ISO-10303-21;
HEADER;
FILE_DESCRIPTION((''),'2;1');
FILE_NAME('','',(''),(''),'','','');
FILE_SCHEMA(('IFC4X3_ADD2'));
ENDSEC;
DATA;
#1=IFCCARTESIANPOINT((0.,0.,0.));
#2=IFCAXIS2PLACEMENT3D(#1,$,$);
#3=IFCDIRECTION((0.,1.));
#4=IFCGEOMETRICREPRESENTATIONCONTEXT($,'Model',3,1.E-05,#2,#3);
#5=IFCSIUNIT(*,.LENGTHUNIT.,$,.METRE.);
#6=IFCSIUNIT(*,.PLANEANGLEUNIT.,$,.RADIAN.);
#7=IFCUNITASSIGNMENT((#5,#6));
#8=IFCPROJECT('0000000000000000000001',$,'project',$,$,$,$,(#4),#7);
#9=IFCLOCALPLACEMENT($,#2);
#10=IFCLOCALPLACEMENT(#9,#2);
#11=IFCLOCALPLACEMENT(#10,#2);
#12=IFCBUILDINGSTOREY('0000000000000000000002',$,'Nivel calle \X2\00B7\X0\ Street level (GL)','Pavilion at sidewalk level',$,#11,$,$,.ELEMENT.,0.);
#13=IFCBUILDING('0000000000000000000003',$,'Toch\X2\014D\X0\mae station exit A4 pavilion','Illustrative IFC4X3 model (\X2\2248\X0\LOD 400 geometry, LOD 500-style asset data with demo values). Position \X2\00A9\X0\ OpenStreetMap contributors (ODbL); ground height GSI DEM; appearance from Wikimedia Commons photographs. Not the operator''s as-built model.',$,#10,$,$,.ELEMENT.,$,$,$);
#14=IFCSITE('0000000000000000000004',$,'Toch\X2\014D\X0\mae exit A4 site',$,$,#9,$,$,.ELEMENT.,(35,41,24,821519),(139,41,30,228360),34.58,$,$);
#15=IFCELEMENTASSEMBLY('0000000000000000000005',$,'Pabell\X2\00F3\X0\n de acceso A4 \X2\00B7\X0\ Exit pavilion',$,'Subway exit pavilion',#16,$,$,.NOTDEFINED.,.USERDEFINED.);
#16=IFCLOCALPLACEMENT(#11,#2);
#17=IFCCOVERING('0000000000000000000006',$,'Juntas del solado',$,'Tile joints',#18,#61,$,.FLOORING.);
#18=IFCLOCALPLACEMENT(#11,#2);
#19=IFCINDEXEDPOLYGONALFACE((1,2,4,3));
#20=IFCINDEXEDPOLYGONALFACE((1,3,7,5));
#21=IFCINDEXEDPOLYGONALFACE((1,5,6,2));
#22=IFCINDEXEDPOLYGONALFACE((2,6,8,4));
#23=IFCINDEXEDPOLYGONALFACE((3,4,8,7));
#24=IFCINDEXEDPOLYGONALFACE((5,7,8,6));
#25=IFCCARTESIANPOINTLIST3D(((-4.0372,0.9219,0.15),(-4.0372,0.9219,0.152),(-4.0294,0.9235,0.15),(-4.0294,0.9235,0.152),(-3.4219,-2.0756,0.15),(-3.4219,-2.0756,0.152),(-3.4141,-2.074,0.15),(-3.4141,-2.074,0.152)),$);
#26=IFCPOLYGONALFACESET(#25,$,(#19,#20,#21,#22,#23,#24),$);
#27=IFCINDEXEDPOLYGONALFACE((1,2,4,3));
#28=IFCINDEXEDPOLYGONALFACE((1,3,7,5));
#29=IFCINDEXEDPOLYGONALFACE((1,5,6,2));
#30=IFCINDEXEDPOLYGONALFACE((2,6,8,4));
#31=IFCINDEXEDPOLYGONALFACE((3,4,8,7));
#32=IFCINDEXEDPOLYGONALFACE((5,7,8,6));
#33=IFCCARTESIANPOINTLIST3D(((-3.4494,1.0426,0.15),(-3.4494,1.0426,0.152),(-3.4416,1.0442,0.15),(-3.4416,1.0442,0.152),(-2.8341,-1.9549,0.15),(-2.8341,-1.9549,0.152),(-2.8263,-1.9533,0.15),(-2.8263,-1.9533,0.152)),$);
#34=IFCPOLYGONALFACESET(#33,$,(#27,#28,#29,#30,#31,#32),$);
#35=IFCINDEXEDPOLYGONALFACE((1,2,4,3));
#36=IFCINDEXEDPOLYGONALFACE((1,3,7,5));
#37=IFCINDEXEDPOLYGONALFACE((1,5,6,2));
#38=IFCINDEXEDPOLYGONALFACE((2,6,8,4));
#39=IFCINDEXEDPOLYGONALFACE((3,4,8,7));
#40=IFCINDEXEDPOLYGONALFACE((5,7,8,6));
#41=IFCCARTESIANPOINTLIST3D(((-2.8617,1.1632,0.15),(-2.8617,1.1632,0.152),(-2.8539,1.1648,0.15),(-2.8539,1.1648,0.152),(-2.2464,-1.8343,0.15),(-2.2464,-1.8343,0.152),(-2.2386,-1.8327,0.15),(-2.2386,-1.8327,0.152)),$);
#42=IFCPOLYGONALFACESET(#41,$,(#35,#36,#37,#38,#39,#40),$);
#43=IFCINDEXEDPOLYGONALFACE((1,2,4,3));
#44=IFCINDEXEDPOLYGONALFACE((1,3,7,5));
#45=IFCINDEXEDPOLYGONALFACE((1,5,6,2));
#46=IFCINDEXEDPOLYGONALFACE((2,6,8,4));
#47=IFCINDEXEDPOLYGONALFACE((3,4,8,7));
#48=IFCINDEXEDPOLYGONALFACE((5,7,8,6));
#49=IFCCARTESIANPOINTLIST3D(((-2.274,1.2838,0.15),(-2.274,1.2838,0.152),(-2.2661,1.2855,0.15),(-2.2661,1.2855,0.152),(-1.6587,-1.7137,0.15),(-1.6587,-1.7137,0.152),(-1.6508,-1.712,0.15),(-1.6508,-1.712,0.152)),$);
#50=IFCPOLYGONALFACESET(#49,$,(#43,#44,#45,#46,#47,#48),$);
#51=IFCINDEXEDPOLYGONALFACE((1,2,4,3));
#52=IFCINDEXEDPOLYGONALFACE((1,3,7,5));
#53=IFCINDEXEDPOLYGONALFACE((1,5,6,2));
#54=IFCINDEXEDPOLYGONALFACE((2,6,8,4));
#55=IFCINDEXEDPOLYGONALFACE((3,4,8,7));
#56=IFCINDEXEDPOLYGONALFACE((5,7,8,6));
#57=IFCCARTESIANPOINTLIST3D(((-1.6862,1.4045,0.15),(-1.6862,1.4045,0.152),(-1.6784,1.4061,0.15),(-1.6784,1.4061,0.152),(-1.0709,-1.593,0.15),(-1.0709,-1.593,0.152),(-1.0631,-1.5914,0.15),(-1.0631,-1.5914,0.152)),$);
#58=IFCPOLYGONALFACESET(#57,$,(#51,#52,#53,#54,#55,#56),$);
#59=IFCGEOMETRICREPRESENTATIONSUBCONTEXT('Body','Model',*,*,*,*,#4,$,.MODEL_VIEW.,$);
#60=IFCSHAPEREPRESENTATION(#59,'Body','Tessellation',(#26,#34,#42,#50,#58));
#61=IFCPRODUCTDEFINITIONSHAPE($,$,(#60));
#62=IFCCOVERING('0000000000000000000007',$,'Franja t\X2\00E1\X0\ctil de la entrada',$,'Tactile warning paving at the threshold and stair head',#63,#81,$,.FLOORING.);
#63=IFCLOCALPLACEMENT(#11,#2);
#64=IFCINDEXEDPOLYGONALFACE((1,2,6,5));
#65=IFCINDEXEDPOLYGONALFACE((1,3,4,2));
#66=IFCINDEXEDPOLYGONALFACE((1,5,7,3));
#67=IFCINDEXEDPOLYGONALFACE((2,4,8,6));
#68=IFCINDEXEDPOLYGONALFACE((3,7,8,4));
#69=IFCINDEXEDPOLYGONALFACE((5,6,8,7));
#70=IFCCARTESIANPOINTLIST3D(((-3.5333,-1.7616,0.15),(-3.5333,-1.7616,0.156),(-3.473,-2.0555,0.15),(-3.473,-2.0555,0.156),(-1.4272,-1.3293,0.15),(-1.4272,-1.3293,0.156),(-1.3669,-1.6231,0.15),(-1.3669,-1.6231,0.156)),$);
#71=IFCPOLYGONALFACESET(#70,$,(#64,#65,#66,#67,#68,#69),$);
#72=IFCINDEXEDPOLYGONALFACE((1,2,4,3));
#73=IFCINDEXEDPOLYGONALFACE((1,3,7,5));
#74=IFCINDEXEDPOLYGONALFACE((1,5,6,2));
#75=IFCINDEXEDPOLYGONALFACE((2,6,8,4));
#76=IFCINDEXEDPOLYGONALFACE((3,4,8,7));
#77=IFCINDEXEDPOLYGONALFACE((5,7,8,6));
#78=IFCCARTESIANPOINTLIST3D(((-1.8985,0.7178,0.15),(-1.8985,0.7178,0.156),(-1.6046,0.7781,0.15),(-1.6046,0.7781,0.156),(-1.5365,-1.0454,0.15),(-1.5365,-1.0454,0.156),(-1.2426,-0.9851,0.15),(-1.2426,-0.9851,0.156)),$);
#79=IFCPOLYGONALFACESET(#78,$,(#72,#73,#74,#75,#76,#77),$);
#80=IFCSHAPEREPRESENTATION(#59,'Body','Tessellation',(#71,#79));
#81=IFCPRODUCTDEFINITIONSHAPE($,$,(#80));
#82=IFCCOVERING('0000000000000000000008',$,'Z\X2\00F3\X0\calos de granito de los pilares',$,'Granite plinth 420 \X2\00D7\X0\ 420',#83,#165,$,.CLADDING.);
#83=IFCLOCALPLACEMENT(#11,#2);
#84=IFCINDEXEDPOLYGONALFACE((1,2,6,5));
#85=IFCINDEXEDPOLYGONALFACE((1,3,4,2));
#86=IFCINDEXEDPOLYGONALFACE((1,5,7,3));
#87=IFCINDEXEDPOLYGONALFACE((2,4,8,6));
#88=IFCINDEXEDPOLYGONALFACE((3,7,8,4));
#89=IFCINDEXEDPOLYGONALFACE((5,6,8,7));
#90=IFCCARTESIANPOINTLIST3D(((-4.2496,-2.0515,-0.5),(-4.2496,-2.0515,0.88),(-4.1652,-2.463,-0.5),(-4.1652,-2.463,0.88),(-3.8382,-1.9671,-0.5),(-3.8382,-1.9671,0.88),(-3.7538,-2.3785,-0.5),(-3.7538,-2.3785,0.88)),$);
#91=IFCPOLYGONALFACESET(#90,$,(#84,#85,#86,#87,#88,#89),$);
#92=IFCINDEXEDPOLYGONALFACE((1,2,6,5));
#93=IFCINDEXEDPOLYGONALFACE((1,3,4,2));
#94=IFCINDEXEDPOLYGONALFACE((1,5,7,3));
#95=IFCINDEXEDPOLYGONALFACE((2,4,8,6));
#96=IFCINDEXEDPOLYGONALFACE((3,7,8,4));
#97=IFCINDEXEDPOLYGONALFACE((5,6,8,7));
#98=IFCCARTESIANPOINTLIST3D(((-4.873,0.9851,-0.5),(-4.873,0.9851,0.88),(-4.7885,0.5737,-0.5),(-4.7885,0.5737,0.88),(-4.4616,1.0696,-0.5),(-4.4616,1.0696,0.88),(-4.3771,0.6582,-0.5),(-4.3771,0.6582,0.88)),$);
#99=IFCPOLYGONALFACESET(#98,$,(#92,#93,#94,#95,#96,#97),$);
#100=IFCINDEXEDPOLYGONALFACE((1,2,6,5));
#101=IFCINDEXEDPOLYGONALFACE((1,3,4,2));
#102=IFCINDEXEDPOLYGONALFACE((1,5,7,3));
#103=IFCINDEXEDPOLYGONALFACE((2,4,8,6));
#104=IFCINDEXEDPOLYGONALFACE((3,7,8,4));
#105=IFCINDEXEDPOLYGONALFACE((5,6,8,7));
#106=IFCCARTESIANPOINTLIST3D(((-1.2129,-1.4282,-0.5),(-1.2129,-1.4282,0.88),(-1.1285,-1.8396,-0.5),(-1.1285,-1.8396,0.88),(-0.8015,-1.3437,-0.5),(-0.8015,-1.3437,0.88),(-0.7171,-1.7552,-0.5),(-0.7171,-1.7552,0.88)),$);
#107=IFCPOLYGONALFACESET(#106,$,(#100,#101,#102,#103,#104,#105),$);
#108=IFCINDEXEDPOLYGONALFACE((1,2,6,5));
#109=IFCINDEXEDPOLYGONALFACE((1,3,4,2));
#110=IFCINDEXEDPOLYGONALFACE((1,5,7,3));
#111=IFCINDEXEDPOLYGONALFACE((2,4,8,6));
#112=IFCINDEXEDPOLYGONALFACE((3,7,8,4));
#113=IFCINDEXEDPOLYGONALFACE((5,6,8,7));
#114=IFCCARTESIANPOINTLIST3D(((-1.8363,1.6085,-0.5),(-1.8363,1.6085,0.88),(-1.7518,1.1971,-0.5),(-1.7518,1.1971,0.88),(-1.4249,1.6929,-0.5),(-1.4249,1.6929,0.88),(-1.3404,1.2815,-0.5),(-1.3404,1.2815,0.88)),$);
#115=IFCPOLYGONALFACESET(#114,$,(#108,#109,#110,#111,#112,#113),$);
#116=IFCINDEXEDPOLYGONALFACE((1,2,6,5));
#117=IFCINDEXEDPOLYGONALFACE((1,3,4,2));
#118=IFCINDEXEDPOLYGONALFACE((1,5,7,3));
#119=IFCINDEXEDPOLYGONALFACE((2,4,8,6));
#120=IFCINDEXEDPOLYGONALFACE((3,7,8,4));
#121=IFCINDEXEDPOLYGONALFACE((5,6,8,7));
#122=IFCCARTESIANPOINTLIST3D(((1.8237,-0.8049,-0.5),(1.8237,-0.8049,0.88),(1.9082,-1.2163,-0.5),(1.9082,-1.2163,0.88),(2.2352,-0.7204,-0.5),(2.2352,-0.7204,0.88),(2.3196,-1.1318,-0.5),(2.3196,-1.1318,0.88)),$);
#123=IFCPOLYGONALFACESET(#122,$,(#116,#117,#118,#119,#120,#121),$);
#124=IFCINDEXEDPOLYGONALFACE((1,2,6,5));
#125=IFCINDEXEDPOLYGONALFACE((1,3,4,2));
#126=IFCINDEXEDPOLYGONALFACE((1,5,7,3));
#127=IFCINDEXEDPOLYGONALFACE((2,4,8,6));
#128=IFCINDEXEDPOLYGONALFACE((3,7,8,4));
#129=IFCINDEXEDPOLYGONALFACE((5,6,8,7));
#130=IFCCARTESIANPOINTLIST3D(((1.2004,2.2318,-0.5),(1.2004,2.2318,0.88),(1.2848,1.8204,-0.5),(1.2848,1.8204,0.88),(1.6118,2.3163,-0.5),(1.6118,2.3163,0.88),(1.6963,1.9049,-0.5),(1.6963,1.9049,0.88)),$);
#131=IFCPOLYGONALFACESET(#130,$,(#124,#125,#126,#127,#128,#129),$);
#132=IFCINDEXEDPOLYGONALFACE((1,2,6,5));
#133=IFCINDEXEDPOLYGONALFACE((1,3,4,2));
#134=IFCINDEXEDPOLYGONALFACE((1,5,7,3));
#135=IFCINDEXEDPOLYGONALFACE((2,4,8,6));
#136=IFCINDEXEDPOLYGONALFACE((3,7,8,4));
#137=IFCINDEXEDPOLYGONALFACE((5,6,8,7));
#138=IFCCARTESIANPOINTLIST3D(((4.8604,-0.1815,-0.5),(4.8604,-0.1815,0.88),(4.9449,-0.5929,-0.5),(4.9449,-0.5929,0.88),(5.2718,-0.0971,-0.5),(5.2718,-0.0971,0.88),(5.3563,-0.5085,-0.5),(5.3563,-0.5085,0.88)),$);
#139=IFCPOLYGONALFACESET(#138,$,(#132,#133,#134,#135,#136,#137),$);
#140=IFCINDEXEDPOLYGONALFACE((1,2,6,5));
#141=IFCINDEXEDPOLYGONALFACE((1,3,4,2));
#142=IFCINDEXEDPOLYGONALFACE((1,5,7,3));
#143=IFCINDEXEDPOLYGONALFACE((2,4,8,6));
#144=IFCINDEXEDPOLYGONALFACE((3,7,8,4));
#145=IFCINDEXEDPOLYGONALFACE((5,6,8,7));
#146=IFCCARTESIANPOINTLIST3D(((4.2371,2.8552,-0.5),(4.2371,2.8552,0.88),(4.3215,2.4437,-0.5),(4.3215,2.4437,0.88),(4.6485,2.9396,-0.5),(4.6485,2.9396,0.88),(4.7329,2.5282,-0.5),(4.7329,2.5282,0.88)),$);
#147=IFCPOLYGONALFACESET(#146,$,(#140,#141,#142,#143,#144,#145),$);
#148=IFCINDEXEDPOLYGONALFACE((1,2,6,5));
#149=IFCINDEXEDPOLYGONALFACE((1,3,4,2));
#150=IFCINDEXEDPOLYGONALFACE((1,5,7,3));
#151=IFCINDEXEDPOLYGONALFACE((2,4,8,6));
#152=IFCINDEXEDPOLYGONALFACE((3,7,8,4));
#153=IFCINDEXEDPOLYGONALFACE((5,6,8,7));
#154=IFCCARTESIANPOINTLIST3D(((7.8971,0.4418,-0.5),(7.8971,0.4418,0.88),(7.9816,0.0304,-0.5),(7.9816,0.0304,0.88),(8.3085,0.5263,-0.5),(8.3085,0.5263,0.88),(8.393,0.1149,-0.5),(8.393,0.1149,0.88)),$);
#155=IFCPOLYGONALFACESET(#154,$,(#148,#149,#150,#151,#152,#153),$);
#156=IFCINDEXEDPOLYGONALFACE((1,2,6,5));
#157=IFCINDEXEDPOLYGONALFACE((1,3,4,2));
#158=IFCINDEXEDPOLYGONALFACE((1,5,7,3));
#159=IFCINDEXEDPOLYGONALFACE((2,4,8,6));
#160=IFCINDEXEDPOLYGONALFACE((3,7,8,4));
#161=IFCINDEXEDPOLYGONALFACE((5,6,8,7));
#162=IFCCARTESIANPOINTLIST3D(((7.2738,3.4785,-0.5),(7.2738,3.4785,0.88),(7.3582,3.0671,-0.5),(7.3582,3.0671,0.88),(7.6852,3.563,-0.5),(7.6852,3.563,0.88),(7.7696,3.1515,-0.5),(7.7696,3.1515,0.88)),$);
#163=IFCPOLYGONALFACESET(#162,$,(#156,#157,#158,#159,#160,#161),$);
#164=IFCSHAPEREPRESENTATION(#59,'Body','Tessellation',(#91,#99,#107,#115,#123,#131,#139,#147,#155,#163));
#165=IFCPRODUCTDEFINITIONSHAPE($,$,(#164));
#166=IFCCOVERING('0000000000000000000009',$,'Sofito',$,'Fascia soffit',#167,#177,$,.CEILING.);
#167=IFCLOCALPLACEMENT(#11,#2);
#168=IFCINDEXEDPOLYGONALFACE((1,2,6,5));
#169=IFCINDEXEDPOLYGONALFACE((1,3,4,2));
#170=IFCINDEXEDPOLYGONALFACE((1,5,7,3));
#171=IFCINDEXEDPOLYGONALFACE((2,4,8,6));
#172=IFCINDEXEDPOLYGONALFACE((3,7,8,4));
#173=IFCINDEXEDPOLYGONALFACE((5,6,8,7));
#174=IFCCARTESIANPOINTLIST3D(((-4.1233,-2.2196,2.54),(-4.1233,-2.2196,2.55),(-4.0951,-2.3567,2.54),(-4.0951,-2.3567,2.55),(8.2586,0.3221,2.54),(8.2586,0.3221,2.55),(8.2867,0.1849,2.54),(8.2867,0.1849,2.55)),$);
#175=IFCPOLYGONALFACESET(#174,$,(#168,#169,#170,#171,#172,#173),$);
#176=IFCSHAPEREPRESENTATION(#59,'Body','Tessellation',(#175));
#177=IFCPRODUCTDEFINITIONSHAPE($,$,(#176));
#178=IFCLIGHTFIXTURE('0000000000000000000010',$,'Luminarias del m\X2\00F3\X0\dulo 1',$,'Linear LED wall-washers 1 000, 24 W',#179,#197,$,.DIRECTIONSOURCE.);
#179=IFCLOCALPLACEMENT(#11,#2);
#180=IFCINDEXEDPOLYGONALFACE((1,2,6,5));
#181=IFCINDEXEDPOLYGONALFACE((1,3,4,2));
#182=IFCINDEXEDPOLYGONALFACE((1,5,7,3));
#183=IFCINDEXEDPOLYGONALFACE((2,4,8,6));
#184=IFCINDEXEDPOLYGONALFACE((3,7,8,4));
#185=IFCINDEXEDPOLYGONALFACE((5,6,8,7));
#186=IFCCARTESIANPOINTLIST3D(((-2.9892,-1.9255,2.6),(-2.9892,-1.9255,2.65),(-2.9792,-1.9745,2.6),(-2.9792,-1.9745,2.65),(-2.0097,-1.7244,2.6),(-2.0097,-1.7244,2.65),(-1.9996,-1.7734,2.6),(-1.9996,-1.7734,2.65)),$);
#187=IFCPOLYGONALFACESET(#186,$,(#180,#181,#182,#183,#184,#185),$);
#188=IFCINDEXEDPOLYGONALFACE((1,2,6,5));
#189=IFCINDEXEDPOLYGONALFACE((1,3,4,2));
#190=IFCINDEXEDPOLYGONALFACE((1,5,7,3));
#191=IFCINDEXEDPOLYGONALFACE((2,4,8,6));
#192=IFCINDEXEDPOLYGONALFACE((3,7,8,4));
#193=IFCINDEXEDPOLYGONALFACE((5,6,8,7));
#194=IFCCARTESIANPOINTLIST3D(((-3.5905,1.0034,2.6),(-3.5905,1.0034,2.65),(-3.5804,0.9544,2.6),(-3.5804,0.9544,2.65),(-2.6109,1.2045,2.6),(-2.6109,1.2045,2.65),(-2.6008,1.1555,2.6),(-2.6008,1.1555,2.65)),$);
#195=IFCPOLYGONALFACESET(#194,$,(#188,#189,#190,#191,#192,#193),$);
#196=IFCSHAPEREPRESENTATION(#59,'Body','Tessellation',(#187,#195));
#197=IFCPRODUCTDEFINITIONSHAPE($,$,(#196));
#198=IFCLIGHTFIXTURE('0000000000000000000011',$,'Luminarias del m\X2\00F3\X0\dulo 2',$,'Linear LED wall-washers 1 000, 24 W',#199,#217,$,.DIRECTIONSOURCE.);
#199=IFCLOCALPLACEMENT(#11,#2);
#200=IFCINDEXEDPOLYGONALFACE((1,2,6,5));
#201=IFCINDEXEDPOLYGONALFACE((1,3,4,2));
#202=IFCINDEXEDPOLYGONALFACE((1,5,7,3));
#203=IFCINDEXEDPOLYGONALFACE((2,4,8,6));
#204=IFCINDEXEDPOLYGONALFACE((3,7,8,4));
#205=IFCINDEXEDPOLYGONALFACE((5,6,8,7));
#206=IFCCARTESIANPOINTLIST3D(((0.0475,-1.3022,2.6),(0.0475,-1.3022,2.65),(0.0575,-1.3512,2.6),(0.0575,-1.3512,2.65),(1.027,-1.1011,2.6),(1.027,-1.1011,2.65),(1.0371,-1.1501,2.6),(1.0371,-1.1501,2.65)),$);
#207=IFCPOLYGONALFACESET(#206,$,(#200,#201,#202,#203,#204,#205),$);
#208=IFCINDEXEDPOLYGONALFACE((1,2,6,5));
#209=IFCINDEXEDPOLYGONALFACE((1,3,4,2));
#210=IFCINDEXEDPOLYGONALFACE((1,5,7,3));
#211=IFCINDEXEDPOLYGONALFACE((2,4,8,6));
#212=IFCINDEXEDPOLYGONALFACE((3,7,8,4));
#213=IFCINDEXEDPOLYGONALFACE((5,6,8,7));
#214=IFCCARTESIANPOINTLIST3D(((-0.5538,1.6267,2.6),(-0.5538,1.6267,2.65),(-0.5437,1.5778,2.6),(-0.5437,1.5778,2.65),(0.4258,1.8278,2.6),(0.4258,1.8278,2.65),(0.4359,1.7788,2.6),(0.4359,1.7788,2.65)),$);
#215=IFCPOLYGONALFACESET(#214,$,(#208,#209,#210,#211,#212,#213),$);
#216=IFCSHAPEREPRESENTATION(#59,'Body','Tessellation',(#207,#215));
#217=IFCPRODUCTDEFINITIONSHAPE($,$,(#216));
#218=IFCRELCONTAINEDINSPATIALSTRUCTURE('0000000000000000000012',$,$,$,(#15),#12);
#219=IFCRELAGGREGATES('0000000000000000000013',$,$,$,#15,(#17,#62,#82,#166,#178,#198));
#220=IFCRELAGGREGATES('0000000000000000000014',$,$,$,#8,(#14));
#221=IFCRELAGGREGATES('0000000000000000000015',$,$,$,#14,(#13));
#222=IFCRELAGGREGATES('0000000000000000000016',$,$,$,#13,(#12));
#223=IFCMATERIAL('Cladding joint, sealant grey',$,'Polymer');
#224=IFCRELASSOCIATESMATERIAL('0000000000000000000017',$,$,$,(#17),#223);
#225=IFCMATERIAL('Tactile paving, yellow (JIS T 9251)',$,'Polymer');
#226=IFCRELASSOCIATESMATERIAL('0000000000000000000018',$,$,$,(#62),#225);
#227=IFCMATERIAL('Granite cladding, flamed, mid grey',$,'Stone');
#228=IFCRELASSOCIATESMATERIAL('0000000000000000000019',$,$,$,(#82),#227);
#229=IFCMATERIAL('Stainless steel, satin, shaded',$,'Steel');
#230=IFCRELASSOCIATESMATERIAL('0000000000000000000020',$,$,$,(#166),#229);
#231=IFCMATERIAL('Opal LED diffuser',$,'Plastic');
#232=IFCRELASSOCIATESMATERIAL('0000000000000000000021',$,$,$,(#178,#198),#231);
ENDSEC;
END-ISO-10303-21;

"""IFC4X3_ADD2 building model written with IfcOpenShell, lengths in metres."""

from ifc_helpers import new_model, si_unit, direction, frame, frame_2d, origin, place, context, subcontext, project, spatial, rectangle, extrude, material, element, aggregate, save


model = new_model("IFC4X3_ADD2")

# Units and contexts
model_context = context("Model", 3, precision=1e-05, world=origin(), true_north=direction((0.0, 1.0)))
body_context = subcontext(model_context, "Body", "Model", "MODEL_VIEW")
ifc_project = project(units=[si_unit("LENGTHUNIT", "METRE"), si_unit("PLANEANGLEUNIT", "RADIAN")], contexts=[model_context])

# Site, building, storey
site_placement = place(None, origin())
site = spatial("IfcSite", under=ifc_project, at=site_placement, Name="Tochōmae exit A4 site", CompositionType="ELEMENT", RefLatitude=(35, 41, 24, 821519), RefLongitude=(139, 41, 30, 228360), RefElevation=34.58)
building_placement = place(site_placement, origin())
building = spatial("IfcBuilding", under=site, at=building_placement, Name="Tochōmae station exit A4 pavilion", Description="Illustrative IFC4X3 model (≈LOD 400 geometry, LOD 500-style asset data with demo values). Position © OpenStreetMap contributors (ODbL); ground height GSI DEM; appearance from Wikimedia Commons photographs. Not the operator's as-built model.", CompositionType="ELEMENT")
storey_placement = place(building_placement, origin())
storey = spatial("IfcBuildingStorey", under=building, at=storey_placement, Name="Nivel calle · Street level (GL)", Description="Pavilion at sidewalk level", CompositionType="ELEMENT", Elevation=0.0)

# Element assembly, coverings, light fixtures
assembly_1_placement = place(building_placement, origin())
assembly_1 = element("IfcElementAssembly", 1, at=assembly_1_placement, inside=storey, Name="Pabellón de acceso A4 · Exit pavilion", ObjectType="Subway exit pavilion", AssemblyPlace="NOTDEFINED", PredefinedType="USERDEFINED")
ifc_material_1 = material(Name="Granite cladding, flamed, mid grey", Category="Stone")
ifc_material_2 = material(Name="Cladding joint, sealant grey", Category="Polymer")
covering_1_placement = place(building_placement, origin())
covering_1 = element("IfcCovering", 2, at=covering_1_placement, material=ifc_material_2, Name="Juntas del solado", ObjectType="Tile joints", PredefinedType="FLOORING", context=body_context, shape_type="SweptSolid", body=[
    extrude(rectangle(XDim=0.008, YDim=3.06, at=frame_2d((0.0, 0.0), x_axis=(0.979575, 0.201078))), frame((-3.7256, -0.576, 0.15)), (0.0, 0.0, 1.0), 0.002),
    extrude(rectangle(XDim=0.008, YDim=3.06, at=frame_2d((0.0, 0.0), x_axis=(0.979575, 0.201078))), frame((-3.1379, -0.4554, 0.15)), (0.0, 0.0, 1.0), 0.002),
    extrude(rectangle(XDim=0.008, YDim=3.06, at=frame_2d((0.0, 0.0), x_axis=(0.979575, 0.201078))), frame((-2.5501, -0.3347, 0.15)), (0.0, 0.0, 1.0), 0.002),
    extrude(rectangle(XDim=0.008, YDim=3.06, at=frame_2d((0.0, 0.0), x_axis=(0.979575, 0.201078))), frame((-1.9624, -0.2141, 0.15)), (0.0, 0.0, 1.0), 0.002),
    extrude(rectangle(XDim=0.008, YDim=3.06, at=frame_2d((0.0, 0.0), x_axis=(0.979575, 0.201078))), frame((-1.3746, -0.0934, 0.15)), (0.0, 0.0, 1.0), 0.002),
])
ifc_material_3 = material(Name="Tactile paving, yellow (JIS T 9251)", Category="Polymer")
covering_2_placement = place(building_placement, origin())
covering_2 = element("IfcCovering", 3, at=covering_2_placement, material=ifc_material_3, Name="Franja táctil de la entrada", ObjectType="Tactile warning paving at the threshold and stair head", PredefinedType="FLOORING", context=body_context, shape_type="SweptSolid", body=[
    extrude(rectangle(XDim=2.15, YDim=0.3, at=frame_2d((0.0, 0.0), x_axis=(0.979575, 0.201078))), frame((-2.4501, -1.6924, 0.15)), (0.0, 0.0, 1.0), 0.006),
    extrude(rectangle(XDim=0.3, YDim=1.8, at=frame_2d((0.0, 0.0), x_axis=(0.979575, 0.201078))), frame((-1.5706, -0.1337, 0.15)), (0.0, 0.0, 1.0), 0.006),
])
covering_3_placement = place(building_placement, origin())
covering_3 = element("IfcCovering", 4, at=covering_3_placement, material=ifc_material_1, Name="Zócalos de granito de los pilares", ObjectType="Granite plinth 420 × 420", PredefinedType="CLADDING", context=body_context, shape_type="SweptSolid", body=[
    extrude(rectangle(XDim=0.42, YDim=0.42, at=frame_2d((0.0, 0.0), x_axis=(0.979575, 0.201078))), frame((-4.0017, -2.215, -0.5)), (0.0, 0.0, 1.0), 1.38),
    extrude(rectangle(XDim=0.42, YDim=0.42, at=frame_2d((0.0, 0.0), x_axis=(0.979575, 0.201078))), frame((-4.625, 0.8217, -0.5)), (0.0, 0.0, 1.0), 1.38),
    extrude(rectangle(XDim=0.42, YDim=0.42, at=frame_2d((0.0, 0.0), x_axis=(0.979575, 0.201078))), frame((-0.965, -1.5917, -0.5)), (0.0, 0.0, 1.0), 1.38),
    extrude(rectangle(XDim=0.42, YDim=0.42, at=frame_2d((0.0, 0.0), x_axis=(0.979575, 0.201078))), frame((-1.5884, 1.445, -0.5)), (0.0, 0.0, 1.0), 1.38),
    extrude(rectangle(XDim=0.42, YDim=0.42, at=frame_2d((0.0, 0.0), x_axis=(0.979575, 0.201078))), frame((2.0717, -0.9683, -0.5)), (0.0, 0.0, 1.0), 1.38),
    extrude(rectangle(XDim=0.42, YDim=0.42, at=frame_2d((0.0, 0.0), x_axis=(0.979575, 0.201078))), frame((1.4483, 2.0683, -0.5)), (0.0, 0.0, 1.0), 1.38),
    extrude(rectangle(XDim=0.42, YDim=0.42, at=frame_2d((0.0, 0.0), x_axis=(0.979575, 0.201078))), frame((5.1084, -0.345, -0.5)), (0.0, 0.0, 1.0), 1.38),
    extrude(rectangle(XDim=0.42, YDim=0.42, at=frame_2d((0.0, 0.0), x_axis=(0.979575, 0.201078))), frame((4.485, 2.6917, -0.5)), (0.0, 0.0, 1.0), 1.38),
    extrude(rectangle(XDim=0.42, YDim=0.42, at=frame_2d((0.0, 0.0), x_axis=(0.979575, 0.201078))), frame((8.145, 0.2783, -0.5)), (0.0, 0.0, 1.0), 1.38),
    extrude(rectangle(XDim=0.42, YDim=0.42, at=frame_2d((0.0, 0.0), x_axis=(0.979575, 0.201078))), frame((7.5217, 3.315, -0.5)), (0.0, 0.0, 1.0), 1.38),
])
ifc_material_4 = material(Name="Stainless steel, satin, shaded", Category="Steel")
covering_4_placement = place(building_placement, origin())
covering_4 = element("IfcCovering", 5, at=covering_4_placement, material=ifc_material_4, Name="Sofito", ObjectType="Fascia soffit", PredefinedType="CEILING", context=body_context, shape_type="SweptSolid", body=[
    extrude(rectangle(XDim=12.64, YDim=0.14, at=frame_2d((0.0, 0.0), x_axis=(0.979575, 0.201078))), frame((2.0817, -1.0173, 2.54)), (0.0, 0.0, 1.0), 0.01),
])
ifc_material_5 = material(Name="Opal LED diffuser", Category="Plastic")
light_fixture_1_placement = place(building_placement, origin())
light_fixture_1 = element("IfcLightFixture", 6, at=light_fixture_1_placement, material=ifc_material_5, Name="Luminarias del módulo 1", ObjectType="Linear LED wall-washers 1 000, 24 W", PredefinedType="DIRECTIONSOURCE", context=body_context, shape_type="SweptSolid", body=[
    extrude(rectangle(XDim=1.0, YDim=0.05, at=frame_2d((0.0, 0.0), x_axis=(0.979575, 0.201078))), frame((-2.4944, -1.8495, 2.6)), (0.0, 0.0, 1.0), 0.05),
    extrude(rectangle(XDim=1.0, YDim=0.05, at=frame_2d((0.0, 0.0), x_axis=(0.979575, 0.201078))), frame((-3.0956, 1.0795, 2.6)), (0.0, 0.0, 1.0), 0.05),
])
light_fixture_2_placement = place(building_placement, origin())
light_fixture_2 = element("IfcLightFixture", 7, at=light_fixture_2_placement, material=ifc_material_5, Name="Luminarias del módulo 2", ObjectType="Linear LED wall-washers 1 000, 24 W", PredefinedType="DIRECTIONSOURCE", context=body_context, shape_type="SweptSolid", body=[
    extrude(rectangle(XDim=1.0, YDim=0.05, at=frame_2d((0.0, 0.0), x_axis=(0.979575, 0.201078))), frame((0.5423, -1.2261, 2.6)), (0.0, 0.0, 1.0), 0.05),
    extrude(rectangle(XDim=1.0, YDim=0.05, at=frame_2d((0.0, 0.0), x_axis=(0.979575, 0.201078))), frame((-0.059, 1.7028, 2.6)), (0.0, 0.0, 1.0), 0.05),
])
aggregate(assembly_1, [covering_1, covering_2, covering_3, covering_4, light_fixture_1, light_fixture_2])

save(model, "model.ifc")
